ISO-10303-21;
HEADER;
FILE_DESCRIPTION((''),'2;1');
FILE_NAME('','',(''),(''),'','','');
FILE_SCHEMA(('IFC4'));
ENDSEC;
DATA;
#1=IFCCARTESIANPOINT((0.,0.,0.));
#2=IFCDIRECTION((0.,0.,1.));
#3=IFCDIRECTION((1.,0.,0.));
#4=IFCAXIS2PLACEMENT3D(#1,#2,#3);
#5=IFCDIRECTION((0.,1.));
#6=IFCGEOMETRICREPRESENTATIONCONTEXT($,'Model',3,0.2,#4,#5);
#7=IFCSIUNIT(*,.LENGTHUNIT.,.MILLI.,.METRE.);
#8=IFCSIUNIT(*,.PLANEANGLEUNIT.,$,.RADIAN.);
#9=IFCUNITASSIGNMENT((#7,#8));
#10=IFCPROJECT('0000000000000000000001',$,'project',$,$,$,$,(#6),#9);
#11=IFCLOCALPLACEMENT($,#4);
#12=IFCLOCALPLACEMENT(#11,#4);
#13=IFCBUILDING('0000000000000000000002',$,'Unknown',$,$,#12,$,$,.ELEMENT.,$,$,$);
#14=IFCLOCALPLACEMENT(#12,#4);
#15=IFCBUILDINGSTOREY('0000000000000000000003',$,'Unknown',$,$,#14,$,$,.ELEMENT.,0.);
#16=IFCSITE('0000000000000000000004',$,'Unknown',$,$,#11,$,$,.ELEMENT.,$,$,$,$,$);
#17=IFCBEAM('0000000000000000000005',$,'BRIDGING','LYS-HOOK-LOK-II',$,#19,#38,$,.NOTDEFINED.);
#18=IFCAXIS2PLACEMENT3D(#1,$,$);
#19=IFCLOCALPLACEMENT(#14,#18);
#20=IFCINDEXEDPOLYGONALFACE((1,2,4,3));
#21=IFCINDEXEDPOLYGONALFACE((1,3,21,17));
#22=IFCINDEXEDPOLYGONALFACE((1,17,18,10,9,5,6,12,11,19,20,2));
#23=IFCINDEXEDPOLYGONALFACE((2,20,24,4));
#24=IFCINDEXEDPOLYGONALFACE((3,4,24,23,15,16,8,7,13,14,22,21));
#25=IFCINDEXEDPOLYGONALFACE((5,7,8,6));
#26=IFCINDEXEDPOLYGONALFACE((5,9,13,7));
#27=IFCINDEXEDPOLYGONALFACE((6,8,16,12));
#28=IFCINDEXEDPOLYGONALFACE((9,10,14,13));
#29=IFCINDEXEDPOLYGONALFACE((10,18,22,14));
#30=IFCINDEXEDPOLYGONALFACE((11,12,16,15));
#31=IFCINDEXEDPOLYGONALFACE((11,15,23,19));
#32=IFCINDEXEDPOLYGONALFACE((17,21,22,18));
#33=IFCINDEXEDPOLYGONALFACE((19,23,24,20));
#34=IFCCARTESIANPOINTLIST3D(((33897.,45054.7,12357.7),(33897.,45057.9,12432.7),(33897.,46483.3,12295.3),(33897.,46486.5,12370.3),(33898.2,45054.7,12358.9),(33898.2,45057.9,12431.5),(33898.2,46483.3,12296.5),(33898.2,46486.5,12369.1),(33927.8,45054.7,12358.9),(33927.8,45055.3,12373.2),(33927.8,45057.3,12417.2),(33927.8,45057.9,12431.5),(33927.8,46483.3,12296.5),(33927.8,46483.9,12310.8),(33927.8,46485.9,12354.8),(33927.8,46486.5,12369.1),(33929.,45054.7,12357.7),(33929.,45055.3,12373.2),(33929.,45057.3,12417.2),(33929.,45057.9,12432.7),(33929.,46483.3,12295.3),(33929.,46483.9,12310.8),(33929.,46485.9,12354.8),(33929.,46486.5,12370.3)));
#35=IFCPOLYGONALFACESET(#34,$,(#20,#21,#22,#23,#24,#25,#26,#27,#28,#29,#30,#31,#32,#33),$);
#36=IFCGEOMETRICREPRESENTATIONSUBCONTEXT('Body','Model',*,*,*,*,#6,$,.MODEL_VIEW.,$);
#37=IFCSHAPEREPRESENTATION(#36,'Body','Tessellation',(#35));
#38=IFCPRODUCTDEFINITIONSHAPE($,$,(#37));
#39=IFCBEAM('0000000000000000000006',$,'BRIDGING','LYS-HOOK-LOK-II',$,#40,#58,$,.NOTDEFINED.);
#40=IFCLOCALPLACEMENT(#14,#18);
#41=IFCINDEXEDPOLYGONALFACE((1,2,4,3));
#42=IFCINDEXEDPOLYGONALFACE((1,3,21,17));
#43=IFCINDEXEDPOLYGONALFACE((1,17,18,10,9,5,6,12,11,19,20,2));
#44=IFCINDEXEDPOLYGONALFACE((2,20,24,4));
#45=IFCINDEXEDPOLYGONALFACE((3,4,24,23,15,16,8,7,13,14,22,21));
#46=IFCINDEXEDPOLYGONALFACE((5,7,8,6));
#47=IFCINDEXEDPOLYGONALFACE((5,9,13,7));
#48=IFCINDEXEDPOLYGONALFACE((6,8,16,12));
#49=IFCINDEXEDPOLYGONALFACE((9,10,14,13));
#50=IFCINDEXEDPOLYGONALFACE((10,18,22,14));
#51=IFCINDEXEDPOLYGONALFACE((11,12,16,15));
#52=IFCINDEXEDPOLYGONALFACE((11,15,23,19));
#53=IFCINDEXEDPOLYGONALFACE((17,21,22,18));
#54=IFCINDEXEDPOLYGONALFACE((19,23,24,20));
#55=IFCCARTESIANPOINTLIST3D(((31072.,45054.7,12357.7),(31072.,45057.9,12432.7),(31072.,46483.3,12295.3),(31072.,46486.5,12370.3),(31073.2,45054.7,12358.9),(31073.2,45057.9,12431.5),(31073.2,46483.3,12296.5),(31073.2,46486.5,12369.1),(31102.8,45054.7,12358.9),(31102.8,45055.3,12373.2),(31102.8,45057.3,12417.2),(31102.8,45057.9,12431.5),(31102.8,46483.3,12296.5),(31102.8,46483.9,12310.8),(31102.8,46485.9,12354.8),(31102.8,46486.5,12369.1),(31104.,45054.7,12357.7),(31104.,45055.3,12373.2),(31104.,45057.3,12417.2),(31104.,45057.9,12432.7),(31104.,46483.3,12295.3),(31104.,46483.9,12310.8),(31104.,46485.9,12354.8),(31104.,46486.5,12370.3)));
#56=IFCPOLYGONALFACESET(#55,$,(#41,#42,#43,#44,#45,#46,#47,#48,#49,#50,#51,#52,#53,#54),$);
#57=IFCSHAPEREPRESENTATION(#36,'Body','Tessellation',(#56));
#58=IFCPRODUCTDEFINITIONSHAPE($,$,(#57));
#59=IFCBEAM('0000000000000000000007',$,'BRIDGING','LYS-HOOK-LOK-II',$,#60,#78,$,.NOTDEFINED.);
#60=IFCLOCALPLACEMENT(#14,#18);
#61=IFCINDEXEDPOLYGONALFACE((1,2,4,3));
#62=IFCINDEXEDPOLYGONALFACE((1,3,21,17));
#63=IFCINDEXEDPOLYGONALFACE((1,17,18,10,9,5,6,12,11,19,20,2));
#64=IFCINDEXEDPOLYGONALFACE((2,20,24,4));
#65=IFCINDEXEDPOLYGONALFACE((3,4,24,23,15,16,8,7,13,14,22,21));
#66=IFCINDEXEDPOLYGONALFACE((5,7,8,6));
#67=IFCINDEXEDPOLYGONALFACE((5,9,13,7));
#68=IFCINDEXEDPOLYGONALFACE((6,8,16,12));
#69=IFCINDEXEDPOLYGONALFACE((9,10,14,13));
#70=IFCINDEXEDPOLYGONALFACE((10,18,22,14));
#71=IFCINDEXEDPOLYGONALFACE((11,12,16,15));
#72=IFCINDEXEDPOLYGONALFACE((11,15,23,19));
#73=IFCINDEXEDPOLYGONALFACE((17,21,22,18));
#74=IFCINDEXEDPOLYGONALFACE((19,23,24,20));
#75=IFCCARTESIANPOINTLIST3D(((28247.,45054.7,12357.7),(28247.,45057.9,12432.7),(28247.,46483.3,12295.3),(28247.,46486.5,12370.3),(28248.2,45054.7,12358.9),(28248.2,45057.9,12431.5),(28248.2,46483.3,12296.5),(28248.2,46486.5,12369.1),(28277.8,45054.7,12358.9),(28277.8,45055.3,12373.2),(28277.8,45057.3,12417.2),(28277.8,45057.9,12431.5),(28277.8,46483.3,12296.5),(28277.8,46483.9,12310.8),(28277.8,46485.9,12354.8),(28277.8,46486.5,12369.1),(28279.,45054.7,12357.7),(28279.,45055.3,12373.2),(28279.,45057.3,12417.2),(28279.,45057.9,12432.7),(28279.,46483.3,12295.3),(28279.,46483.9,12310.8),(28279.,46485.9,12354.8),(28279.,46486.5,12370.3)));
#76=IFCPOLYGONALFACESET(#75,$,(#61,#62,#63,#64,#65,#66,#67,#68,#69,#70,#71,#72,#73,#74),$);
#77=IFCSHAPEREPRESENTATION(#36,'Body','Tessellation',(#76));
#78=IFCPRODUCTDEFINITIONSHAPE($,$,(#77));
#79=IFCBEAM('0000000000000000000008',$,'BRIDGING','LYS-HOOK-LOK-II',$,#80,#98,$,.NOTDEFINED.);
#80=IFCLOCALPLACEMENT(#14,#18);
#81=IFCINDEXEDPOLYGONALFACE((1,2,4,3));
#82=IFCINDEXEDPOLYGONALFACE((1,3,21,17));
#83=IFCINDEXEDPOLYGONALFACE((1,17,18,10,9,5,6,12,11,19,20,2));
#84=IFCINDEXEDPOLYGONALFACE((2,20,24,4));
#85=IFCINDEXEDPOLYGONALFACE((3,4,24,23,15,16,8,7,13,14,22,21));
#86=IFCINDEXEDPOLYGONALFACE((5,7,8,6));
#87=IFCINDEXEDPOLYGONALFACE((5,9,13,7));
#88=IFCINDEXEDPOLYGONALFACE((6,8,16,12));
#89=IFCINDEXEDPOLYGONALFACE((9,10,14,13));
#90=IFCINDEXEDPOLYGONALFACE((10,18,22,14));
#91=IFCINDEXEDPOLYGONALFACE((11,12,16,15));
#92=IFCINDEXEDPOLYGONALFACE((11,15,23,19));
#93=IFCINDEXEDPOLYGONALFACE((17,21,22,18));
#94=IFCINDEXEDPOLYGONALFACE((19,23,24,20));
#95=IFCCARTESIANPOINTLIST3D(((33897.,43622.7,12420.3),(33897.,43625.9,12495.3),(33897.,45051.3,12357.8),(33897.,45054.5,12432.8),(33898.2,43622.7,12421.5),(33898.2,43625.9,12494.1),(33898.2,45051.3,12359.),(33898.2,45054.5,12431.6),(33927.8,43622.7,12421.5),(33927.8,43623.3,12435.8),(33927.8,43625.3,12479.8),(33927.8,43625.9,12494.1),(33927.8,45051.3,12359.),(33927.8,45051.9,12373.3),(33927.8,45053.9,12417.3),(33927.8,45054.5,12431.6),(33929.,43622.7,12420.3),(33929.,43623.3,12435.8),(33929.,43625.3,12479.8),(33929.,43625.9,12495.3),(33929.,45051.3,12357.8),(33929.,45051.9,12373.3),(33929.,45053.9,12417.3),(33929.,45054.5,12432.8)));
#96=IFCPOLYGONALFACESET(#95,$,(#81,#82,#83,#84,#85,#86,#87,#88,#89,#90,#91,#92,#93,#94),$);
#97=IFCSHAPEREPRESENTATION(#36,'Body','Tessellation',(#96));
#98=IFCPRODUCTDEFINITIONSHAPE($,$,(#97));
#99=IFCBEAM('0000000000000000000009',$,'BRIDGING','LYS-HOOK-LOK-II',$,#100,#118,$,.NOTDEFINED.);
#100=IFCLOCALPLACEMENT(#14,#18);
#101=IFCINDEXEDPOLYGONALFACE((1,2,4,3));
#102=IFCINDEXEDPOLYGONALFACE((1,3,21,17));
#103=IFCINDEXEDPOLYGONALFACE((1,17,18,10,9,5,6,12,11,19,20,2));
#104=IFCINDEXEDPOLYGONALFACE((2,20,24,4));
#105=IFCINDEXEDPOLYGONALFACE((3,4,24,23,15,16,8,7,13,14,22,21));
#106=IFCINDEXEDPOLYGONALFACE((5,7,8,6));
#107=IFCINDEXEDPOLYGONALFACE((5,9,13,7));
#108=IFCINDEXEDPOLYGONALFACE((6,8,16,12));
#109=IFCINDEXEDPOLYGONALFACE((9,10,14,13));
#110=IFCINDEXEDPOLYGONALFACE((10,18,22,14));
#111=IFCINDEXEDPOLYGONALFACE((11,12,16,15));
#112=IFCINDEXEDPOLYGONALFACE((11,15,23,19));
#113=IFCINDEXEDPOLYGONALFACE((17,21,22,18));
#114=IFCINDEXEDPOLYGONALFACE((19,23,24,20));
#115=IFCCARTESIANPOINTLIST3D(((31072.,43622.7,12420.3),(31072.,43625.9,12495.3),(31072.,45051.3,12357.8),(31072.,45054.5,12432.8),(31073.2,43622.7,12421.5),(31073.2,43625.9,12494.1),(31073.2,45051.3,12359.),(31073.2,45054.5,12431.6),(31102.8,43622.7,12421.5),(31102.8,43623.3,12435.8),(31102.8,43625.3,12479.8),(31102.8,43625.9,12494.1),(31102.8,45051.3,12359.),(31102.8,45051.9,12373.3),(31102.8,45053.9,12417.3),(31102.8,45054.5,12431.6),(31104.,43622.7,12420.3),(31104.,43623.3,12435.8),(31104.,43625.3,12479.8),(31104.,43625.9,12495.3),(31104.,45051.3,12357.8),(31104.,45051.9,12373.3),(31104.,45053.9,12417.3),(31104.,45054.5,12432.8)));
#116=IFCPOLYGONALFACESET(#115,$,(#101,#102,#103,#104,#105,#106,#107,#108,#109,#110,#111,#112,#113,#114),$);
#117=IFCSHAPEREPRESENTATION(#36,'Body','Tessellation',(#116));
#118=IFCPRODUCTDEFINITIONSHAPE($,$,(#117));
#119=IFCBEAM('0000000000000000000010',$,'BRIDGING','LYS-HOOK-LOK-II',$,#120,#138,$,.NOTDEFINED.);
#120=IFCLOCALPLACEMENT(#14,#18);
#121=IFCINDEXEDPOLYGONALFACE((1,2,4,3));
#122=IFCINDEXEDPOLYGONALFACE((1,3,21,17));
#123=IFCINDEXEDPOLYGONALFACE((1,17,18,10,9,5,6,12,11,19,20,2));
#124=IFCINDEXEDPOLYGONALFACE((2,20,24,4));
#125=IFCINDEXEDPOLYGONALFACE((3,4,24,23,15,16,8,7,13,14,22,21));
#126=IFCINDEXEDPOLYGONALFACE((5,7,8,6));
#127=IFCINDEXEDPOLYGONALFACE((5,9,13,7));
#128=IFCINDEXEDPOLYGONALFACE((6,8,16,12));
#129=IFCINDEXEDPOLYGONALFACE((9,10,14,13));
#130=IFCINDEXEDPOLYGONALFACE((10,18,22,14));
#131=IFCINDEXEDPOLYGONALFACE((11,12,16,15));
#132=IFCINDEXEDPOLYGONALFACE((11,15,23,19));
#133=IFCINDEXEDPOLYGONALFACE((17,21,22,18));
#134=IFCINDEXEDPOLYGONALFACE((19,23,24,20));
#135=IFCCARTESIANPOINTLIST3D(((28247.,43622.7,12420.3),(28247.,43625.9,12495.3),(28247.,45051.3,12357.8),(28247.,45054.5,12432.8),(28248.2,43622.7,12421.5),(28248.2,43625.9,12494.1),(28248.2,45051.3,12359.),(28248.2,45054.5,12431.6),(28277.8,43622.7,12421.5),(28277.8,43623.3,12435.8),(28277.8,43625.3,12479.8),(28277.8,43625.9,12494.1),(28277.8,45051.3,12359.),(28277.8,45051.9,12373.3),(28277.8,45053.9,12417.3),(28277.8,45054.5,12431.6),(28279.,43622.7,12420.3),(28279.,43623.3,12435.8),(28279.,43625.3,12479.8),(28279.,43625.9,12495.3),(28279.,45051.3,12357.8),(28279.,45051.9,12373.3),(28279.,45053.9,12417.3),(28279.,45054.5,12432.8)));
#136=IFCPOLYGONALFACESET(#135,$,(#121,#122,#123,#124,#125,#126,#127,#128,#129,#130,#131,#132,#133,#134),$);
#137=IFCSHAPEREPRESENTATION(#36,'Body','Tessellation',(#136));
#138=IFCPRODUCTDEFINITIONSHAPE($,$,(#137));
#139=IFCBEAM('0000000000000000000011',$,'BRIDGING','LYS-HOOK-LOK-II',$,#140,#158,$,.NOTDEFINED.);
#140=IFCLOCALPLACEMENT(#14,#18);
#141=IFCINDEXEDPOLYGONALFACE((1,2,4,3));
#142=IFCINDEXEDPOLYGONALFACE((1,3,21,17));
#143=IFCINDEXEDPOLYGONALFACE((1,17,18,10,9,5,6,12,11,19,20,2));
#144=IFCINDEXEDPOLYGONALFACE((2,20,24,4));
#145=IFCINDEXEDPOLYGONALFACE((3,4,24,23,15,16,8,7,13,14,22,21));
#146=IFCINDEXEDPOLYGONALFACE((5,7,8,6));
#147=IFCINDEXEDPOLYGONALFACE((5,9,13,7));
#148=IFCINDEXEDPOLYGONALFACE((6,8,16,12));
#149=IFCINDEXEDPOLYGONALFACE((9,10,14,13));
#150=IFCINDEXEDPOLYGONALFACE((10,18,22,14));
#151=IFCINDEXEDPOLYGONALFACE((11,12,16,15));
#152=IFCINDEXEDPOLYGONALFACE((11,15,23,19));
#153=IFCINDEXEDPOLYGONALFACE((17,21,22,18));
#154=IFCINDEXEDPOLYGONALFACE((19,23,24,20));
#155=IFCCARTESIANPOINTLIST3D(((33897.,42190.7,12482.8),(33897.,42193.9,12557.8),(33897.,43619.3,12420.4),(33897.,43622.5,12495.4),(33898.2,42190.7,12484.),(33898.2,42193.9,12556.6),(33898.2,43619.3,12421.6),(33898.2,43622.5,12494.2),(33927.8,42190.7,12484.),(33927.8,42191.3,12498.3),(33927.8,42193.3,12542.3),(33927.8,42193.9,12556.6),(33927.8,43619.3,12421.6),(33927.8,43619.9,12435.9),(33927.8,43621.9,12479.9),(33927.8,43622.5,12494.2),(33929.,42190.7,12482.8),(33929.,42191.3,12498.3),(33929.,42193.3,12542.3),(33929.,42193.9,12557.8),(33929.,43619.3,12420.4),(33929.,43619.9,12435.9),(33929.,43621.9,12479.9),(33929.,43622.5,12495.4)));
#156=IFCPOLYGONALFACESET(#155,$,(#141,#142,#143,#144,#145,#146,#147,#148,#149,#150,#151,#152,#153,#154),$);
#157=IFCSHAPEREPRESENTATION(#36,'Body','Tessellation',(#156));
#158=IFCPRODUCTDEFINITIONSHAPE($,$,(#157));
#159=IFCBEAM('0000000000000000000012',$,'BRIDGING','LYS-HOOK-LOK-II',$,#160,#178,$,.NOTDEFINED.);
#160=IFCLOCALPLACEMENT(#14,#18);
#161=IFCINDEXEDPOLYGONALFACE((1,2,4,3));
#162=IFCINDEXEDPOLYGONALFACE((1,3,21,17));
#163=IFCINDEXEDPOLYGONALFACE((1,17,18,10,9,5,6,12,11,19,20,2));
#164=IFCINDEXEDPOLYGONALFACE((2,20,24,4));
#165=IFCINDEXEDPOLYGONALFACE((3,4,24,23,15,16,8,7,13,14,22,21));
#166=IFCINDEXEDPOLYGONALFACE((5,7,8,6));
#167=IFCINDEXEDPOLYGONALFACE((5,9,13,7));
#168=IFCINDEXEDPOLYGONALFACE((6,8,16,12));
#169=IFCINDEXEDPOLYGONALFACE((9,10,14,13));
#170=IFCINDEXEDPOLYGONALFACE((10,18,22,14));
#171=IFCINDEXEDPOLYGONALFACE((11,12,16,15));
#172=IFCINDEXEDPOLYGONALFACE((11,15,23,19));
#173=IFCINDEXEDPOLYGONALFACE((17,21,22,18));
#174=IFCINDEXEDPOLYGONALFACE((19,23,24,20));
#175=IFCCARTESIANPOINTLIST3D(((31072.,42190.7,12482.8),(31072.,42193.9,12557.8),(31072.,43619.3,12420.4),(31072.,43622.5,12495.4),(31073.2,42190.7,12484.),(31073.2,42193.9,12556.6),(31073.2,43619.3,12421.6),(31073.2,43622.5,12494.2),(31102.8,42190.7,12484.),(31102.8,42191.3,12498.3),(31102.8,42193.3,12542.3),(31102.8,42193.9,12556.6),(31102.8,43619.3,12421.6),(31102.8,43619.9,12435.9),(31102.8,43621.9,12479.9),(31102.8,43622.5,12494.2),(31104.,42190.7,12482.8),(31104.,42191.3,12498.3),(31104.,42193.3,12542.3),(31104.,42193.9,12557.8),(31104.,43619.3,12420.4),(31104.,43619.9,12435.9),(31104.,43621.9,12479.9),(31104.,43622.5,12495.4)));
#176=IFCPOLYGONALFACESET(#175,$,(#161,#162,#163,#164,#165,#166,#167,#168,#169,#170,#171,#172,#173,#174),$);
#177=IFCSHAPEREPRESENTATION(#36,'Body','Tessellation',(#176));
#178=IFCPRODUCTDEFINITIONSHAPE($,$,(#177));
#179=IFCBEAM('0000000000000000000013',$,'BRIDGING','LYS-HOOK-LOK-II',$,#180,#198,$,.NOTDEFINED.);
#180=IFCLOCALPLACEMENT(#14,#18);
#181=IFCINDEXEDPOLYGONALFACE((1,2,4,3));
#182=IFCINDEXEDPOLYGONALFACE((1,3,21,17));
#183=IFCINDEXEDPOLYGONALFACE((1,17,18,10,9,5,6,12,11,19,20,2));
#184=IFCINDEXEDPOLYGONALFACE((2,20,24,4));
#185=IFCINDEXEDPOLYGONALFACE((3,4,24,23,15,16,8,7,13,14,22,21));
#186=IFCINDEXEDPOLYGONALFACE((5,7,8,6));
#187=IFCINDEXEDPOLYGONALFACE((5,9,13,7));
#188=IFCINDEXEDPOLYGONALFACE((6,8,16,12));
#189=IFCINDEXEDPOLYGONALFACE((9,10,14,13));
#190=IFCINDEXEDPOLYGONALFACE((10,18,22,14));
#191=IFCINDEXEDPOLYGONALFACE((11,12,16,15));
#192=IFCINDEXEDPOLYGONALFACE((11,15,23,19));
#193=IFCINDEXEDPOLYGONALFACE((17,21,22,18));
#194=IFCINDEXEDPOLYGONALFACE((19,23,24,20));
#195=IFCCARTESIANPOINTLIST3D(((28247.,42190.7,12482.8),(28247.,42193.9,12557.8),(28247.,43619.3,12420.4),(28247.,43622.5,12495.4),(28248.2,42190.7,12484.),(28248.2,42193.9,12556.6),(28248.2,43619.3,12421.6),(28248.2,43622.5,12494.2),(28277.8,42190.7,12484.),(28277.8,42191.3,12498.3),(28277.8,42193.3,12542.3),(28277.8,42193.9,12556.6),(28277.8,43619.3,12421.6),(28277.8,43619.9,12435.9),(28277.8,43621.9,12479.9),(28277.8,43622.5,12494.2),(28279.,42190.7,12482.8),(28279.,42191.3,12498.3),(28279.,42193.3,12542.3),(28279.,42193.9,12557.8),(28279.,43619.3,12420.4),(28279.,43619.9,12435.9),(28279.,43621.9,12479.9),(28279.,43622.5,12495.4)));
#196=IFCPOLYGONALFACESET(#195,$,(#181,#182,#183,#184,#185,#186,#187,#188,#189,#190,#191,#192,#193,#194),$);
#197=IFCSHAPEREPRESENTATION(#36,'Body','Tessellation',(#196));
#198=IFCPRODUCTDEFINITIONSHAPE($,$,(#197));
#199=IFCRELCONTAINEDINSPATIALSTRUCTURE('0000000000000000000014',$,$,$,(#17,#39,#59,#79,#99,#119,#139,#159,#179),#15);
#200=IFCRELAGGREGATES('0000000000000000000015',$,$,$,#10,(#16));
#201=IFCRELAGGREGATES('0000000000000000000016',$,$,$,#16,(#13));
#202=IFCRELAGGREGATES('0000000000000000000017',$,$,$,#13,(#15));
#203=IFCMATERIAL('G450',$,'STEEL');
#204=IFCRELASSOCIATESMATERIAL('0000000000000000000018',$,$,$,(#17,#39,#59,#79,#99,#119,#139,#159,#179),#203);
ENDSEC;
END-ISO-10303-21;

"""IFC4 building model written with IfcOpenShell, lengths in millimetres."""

from ifc_helpers import new_model, si_unit, direction, frame, origin_with_axes, place, context, subcontext, project, spatial, line, indexed_curve, outline, extrude, material, element, save


model = new_model("IFC4")

# Units and contexts
model_context = context("Model", 3, precision=0.2, world=origin_with_axes(), true_north=direction((0.0, 1.0)))
body_context = subcontext(model_context, "Body", "Model", "MODEL_VIEW")
ifc_project = project(units=[si_unit("LENGTHUNIT", "METRE", prefix="MILLI"), si_unit("PLANEANGLEUNIT", "RADIAN")], contexts=[model_context])

# Site, building, storey
site_placement = place(None, origin_with_axes())
site = spatial("IfcSite", under=ifc_project, at=site_placement, Name="Unknown", CompositionType="ELEMENT")
building_placement = place(site_placement, origin_with_axes())
building = spatial("IfcBuilding", under=site, at=building_placement, Name="Unknown", CompositionType="ELEMENT")
storey_placement = place(building_placement, origin_with_axes())
storey = spatial("IfcBuildingStorey", under=building, at=storey_placement, Name="Unknown", CompositionType="ELEMENT", Elevation=0.0)

# Beams
ifc_material_1 = material(Name="G450", Category="STEEL")
for number, where, z_axis, x_axis, name in (
    (1, (33913.0, 45056.3, 12395.2), (1.0, 0.0, 0.0), (0.0, 0.999047, -0.043638), "BRIDGING"),
    (2, (31088.0, 45056.3, 12395.2), (1.0, 0.0, 0.0), (0.0, 0.999047, -0.043638), "BRIDGING"),
    (3, (28263.0, 45056.3, 12395.2), (1.0, 0.0, 0.0), (0.0, 0.999047, -0.043638), "BRIDGING"),
):
    element("IfcBeam", number, at=place(storey_placement, frame(where, z_axis=z_axis, x_axis=x_axis)), inside=storey, material=ifc_material_1, Name=name, Description="LYS-HOOK-LOK-II", PredefinedType="NOTDEFINED", context=body_context, shape_type="SolidModel", body=[
        extrude(outline(indexed_curve([(16.0, -37.5), (16.0, -22.0), (14.8, -22.0), (14.8, -36.3), (-14.8, -36.3), (-14.8, 36.3), (14.8, 36.3), (14.8, 22.0), (16.0, 22.0), (16.0, 37.5), (-16.0, 37.5), (-16.0, -37.5)], segments=[line(1, 2, 3, 4, 5, 6, 7, 8, 9, 10, 11, 12, 1)])), frame((0.0, 0.0, 0.0), z_axis=(-1.0, 0.0, 0.0), x_axis=(0.0, 0.0, 1.0)), (0.0, 0.0, -1.0), 1430.0),
    ])
for number, where, z_axis, x_axis, name in (
    (4, (33913.0, 43624.3, 12457.8), (1.0, 0.0, 0.0), (0.0, 0.999044, -0.043707), "BRIDGING"),
    (5, (31088.0, 43624.3, 12457.8), (1.0, 0.0, 0.0), (0.0, 0.999044, -0.043707), "BRIDGING"),
    (6, (28263.0, 43624.3, 12457.8), (1.0, 0.0, 0.0), (0.0, 0.999044, -0.043707), "BRIDGING"),
):
    element("IfcBeam", number, at=place(storey_placement, frame(where, z_axis=z_axis, x_axis=x_axis)), inside=storey, material=ifc_material_1, Name=name, Description="LYS-HOOK-LOK-II", PredefinedType="NOTDEFINED", context=body_context, shape_type="SolidModel", body=[
        extrude(outline(indexed_curve([(16.0, -37.5), (16.0, -22.0), (14.8, -22.0), (14.8, -36.3), (-14.8, -36.3), (-14.8, 36.3), (14.8, 36.3), (14.8, 22.0), (16.0, 22.0), (16.0, 37.5), (-16.0, 37.5), (-16.0, -37.5)], segments=[line(1, 2, 3, 4, 5, 6, 7, 8, 9, 10, 11, 12, 1)])), frame((0.0, 0.0, 0.0), z_axis=(-1.0, 0.0, 0.0), x_axis=(0.0, 0.0, 1.0)), (0.0, 0.0, -1.0), 1430.0),
    ])
for number, where, z_axis, x_axis, name in (
    (7, (33913.0, 42192.3, 12520.3), (1.0, 0.0, 0.0), (0.0, 0.999047, -0.043638), "BRIDGING"),
    (8, (31088.0, 42192.3, 12520.3), (1.0, 0.0, 0.0), (0.0, 0.999047, -0.043638), "BRIDGING"),
    (9, (28263.0, 42192.3, 12520.3), (1.0, 0.0, 0.0), (0.0, 0.999047, -0.043638), "BRIDGING"),
):
    element("IfcBeam", number, at=place(storey_placement, frame(where, z_axis=z_axis, x_axis=x_axis)), inside=storey, material=ifc_material_1, Name=name, Description="LYS-HOOK-LOK-II", PredefinedType="NOTDEFINED", context=body_context, shape_type="SolidModel", body=[
        extrude(outline(indexed_curve([(16.0, -37.5), (16.0, -22.0), (14.8, -22.0), (14.8, -36.3), (-14.8, -36.3), (-14.8, 36.3), (14.8, 36.3), (14.8, 22.0), (16.0, 22.0), (16.0, 37.5), (-16.0, 37.5), (-16.0, -37.5)], segments=[line(1, 2, 3, 4, 5, 6, 7, 8, 9, 10, 11, 12, 1)])), frame((0.0, 0.0, 0.0), z_axis=(-1.0, 0.0, 0.0), x_axis=(0.0, 0.0, 1.0)), (0.0, 0.0, -1.0), 1430.0),
    ])

save(model, "model.ifc")
